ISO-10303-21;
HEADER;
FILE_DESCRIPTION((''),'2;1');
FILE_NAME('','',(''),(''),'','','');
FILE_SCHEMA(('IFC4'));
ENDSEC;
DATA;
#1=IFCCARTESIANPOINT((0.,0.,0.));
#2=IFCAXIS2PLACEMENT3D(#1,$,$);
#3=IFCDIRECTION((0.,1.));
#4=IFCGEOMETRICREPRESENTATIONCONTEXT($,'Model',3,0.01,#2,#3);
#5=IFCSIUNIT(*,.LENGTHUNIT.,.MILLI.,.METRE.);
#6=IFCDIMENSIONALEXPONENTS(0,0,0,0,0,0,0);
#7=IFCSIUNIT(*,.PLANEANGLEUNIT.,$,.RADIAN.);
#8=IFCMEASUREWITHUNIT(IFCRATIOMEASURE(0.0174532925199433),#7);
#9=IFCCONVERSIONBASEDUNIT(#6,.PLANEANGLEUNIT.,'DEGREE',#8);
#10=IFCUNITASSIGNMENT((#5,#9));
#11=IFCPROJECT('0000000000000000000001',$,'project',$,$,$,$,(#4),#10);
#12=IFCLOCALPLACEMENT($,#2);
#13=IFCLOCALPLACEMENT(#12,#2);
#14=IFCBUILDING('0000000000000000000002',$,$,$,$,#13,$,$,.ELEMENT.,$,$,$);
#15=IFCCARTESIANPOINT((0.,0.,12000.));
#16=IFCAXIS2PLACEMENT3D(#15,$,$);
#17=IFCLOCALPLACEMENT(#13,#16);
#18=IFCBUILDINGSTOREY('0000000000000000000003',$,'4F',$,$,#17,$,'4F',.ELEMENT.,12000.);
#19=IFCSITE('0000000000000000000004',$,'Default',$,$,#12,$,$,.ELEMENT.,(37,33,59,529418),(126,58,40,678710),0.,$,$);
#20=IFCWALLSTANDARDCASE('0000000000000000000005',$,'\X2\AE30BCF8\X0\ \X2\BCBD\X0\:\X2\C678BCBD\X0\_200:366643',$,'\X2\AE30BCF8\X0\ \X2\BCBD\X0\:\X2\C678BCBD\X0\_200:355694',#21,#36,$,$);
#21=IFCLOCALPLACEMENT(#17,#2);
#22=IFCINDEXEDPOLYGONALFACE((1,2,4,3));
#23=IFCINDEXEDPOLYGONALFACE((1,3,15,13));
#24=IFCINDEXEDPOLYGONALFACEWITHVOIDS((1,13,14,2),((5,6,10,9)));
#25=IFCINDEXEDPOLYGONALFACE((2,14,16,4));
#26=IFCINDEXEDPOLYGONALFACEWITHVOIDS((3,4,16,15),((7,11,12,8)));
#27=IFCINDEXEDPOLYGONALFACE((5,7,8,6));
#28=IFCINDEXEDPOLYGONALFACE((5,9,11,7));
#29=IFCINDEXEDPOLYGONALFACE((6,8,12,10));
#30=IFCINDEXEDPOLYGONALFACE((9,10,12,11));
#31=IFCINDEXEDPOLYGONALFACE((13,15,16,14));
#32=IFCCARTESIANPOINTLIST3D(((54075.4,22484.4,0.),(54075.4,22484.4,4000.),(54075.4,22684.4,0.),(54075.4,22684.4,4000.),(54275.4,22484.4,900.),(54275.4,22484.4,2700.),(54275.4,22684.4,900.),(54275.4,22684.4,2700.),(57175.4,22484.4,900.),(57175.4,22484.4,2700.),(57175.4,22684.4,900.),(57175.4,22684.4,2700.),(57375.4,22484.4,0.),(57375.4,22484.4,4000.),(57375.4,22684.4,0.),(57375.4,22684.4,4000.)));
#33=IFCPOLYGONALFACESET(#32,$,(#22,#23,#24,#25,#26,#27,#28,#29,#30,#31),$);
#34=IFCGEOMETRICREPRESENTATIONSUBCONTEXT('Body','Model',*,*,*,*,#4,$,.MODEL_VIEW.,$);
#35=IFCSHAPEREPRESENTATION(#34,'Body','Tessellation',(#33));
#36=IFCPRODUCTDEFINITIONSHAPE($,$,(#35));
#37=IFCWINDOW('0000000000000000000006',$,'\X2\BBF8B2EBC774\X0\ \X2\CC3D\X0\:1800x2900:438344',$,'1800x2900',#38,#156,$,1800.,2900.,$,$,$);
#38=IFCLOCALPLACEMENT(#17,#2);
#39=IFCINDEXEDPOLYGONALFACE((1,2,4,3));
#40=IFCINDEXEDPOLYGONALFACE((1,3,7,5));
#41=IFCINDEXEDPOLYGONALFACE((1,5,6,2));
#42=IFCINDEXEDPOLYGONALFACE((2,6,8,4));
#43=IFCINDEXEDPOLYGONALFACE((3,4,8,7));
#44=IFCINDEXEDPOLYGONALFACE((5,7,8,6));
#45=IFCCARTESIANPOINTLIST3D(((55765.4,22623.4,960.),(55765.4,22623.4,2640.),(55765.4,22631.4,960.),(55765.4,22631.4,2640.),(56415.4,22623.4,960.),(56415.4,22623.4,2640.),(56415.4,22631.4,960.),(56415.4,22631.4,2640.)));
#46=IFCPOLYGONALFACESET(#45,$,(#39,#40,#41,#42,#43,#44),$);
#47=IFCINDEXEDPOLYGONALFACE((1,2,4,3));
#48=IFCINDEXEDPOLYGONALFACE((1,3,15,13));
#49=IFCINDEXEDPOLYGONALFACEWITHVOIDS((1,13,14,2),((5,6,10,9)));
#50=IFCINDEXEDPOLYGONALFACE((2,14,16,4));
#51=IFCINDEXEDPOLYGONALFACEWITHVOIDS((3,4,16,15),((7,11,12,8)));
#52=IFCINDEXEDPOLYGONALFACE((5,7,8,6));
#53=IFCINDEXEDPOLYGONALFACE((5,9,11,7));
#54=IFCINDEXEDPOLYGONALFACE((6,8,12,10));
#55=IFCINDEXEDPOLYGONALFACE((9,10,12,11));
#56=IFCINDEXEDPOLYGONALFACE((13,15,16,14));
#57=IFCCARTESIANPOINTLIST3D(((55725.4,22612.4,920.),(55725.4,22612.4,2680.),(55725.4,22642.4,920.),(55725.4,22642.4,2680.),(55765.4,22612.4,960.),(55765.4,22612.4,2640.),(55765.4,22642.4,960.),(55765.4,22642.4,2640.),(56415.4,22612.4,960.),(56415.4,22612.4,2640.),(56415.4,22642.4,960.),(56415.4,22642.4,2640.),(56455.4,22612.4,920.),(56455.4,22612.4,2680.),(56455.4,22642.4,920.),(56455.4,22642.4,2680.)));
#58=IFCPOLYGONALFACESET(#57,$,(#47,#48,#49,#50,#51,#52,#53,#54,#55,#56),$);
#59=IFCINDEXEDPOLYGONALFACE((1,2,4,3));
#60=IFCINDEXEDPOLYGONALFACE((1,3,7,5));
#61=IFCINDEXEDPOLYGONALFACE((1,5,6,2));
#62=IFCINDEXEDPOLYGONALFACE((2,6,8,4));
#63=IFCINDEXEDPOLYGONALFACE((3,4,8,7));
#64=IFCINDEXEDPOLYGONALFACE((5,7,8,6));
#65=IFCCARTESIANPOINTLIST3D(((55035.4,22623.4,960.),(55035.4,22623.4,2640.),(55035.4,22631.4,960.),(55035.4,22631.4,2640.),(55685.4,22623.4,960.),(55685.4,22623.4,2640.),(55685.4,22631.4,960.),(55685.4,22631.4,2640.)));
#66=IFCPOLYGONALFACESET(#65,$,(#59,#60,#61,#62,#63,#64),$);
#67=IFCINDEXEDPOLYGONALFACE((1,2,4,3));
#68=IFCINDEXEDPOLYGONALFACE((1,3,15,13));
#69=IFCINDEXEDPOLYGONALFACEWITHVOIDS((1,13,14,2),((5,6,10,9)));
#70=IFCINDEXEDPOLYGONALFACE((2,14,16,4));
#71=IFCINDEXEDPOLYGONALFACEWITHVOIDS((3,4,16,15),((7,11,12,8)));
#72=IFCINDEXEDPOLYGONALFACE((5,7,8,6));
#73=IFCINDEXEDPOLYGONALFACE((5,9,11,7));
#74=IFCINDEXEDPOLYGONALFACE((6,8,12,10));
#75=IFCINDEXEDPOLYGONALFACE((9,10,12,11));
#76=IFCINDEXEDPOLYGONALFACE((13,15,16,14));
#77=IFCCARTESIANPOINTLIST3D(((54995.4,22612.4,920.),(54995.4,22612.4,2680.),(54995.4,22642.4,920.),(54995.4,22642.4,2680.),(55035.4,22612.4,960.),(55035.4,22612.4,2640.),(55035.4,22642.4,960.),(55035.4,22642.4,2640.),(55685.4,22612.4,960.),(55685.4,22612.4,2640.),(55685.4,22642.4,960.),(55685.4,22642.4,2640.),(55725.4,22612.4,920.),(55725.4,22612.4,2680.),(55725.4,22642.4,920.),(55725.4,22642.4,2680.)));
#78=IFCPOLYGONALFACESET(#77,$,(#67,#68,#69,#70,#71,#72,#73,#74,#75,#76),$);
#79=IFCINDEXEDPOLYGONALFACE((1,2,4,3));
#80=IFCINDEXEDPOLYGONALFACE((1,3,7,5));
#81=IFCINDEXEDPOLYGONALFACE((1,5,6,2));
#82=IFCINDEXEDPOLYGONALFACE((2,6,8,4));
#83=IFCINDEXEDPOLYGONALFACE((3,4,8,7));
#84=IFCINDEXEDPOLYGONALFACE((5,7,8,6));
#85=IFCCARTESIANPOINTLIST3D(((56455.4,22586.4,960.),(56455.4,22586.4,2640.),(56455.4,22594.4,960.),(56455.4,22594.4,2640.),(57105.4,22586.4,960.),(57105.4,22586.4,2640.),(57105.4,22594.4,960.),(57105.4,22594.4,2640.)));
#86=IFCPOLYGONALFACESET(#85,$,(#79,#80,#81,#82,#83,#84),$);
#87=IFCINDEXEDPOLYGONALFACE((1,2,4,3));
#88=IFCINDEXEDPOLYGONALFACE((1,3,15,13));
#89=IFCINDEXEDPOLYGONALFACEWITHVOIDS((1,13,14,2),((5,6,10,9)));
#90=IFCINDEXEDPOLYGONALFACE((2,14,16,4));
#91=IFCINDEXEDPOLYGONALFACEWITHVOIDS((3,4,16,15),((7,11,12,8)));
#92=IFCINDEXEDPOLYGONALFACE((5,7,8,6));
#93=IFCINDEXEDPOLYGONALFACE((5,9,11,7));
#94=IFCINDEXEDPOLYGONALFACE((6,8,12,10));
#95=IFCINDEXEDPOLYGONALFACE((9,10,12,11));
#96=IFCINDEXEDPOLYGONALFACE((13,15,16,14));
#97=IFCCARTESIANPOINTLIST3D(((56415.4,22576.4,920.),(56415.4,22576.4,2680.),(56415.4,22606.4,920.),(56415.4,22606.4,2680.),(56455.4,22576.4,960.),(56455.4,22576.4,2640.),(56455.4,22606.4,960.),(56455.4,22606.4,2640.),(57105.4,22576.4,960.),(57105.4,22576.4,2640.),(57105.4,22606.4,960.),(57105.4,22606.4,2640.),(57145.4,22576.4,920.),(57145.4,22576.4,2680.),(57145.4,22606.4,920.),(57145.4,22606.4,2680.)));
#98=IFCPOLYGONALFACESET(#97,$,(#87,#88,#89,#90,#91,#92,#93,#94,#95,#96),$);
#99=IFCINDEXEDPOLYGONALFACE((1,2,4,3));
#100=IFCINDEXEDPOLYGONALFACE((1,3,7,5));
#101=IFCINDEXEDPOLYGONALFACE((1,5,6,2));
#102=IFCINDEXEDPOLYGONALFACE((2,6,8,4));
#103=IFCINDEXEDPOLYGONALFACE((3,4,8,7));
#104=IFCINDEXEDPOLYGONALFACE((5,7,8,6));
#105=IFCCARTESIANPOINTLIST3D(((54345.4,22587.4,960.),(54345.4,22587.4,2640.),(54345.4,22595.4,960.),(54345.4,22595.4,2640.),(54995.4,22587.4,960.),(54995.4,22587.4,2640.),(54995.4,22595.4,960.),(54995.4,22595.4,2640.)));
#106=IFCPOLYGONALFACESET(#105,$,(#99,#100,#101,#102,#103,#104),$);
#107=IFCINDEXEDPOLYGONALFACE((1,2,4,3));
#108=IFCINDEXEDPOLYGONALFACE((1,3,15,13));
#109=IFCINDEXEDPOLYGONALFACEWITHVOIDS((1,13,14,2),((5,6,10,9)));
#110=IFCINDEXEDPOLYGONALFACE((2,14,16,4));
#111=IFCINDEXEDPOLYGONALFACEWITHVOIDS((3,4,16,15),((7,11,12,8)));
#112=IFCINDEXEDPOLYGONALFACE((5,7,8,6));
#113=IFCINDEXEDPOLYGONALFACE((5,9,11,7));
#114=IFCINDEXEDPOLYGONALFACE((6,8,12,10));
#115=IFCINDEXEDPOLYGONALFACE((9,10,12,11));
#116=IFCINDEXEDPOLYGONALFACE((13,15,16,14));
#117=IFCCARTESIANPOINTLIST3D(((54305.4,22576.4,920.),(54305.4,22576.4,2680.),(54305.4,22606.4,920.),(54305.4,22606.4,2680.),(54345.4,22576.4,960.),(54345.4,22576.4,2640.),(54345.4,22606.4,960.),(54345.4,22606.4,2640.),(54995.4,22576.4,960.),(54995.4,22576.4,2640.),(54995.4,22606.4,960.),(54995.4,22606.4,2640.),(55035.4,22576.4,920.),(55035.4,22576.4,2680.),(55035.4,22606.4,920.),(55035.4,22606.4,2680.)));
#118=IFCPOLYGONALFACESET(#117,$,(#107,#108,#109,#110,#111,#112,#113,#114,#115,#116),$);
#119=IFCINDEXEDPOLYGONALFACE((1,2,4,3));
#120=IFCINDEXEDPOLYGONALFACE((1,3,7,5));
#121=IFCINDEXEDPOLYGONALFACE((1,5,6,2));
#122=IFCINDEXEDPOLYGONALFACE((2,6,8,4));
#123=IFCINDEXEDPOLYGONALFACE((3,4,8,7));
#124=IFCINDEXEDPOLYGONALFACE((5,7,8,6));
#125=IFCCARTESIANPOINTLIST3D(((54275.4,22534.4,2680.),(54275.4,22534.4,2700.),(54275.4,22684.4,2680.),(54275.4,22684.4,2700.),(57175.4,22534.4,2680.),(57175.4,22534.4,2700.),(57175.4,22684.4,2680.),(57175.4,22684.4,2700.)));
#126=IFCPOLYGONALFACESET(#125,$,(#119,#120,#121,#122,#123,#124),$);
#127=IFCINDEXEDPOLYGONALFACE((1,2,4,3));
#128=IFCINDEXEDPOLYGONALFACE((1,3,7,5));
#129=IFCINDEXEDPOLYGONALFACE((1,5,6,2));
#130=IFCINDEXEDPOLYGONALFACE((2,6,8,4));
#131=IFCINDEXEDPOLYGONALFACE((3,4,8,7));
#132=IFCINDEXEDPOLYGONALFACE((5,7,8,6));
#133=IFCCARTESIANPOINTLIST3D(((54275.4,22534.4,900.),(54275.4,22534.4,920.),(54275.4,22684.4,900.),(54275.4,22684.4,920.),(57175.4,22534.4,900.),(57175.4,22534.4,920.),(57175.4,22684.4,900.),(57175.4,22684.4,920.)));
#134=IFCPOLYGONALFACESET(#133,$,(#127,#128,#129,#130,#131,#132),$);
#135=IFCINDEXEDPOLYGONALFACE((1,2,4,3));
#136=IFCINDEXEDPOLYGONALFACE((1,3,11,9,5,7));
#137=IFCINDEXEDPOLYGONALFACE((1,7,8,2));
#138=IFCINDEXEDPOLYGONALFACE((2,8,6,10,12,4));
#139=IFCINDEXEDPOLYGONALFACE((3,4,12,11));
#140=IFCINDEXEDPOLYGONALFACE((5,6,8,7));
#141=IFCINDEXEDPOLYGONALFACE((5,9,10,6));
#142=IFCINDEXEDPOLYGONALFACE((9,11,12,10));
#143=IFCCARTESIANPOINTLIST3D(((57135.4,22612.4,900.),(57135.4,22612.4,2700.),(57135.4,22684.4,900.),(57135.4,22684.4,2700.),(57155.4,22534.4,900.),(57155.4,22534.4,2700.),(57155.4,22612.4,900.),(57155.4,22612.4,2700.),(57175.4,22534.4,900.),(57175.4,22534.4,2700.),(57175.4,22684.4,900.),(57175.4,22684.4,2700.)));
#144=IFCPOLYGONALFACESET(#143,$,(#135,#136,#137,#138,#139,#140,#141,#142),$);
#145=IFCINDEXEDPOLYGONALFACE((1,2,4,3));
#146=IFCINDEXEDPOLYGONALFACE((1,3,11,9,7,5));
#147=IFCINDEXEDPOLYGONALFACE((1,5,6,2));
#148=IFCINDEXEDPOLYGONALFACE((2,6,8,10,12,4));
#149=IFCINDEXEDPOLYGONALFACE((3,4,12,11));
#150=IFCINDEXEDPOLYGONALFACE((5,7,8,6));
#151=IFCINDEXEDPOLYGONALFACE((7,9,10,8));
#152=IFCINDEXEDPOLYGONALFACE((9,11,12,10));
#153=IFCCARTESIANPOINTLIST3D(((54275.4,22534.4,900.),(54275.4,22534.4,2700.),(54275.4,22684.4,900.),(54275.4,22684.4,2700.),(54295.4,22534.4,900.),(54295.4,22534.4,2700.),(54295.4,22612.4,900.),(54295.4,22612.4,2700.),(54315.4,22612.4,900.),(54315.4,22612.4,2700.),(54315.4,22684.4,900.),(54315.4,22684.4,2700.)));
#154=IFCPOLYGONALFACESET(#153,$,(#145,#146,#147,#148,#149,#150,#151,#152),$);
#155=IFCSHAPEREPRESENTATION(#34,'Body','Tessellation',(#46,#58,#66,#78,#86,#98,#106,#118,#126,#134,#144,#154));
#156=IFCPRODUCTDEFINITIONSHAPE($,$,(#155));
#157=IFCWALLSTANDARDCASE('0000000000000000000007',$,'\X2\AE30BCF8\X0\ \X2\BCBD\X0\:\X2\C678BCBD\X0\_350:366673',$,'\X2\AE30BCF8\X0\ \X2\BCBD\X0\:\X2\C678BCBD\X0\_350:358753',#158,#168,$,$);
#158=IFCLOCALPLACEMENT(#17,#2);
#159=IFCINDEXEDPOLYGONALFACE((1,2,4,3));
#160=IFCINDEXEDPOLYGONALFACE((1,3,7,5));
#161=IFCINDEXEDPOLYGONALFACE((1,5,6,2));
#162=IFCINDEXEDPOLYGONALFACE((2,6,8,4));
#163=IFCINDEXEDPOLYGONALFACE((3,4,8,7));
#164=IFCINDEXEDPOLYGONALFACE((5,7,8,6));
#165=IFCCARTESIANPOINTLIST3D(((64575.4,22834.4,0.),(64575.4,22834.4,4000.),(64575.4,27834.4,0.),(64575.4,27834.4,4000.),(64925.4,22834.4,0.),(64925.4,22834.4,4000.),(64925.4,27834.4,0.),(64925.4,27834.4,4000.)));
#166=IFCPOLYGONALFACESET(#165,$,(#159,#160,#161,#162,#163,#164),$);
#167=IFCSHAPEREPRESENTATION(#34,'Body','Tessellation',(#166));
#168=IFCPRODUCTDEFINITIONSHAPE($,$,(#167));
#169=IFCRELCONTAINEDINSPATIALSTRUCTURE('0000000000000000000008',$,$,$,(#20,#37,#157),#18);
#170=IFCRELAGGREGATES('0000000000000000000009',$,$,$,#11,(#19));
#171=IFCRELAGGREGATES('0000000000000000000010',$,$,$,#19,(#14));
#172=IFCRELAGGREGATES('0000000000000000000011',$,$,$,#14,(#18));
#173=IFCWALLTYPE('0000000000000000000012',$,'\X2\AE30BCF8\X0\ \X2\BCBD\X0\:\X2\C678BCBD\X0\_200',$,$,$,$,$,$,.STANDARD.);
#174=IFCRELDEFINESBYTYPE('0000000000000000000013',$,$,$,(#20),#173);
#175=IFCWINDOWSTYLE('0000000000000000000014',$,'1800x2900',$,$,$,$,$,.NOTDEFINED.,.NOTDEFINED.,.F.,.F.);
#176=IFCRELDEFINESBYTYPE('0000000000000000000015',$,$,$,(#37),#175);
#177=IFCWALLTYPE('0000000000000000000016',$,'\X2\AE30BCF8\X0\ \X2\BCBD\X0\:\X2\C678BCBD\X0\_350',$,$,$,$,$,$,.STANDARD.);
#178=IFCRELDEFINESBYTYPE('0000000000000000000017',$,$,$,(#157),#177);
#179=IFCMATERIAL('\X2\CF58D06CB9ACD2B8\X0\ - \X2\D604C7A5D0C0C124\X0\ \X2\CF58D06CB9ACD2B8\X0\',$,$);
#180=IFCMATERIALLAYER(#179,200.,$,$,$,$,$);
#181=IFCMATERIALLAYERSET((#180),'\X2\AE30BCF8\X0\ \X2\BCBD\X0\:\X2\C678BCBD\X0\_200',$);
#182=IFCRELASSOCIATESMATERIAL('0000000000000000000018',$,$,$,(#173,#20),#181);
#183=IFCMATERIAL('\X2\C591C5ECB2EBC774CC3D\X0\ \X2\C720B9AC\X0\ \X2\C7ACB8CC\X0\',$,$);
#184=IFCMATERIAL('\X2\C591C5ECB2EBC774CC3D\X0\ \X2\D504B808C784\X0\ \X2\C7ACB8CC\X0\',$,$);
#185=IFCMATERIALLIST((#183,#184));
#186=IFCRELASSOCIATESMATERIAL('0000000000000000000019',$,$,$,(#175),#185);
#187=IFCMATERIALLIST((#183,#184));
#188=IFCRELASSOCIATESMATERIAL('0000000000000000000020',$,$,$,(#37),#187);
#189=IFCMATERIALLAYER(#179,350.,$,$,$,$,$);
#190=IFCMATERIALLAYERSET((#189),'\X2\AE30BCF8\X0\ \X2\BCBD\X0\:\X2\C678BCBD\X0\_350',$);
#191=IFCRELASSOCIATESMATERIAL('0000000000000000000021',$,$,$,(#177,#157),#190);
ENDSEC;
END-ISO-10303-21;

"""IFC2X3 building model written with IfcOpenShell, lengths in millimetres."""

from ifc_helpers import new_model, entity, si_unit, converted_unit, direction, frame, frame_2d, origin, origin_2d_with_axis, place, context, subcontext, project, spatial, polyline, rectangle, outline, extrude, source, transform, mapped, material, material_list, layer, layer_set, layer_usage, type_object, type_shapes, element, fill, save


model = new_model("IFC2X3")

# Units and contexts
model_context = context("Model", 3, precision=0.01, world=origin(), true_north=direction((0.0, 1.0)))
body_context = subcontext(model_context, "Body", "Model", "MODEL_VIEW")
ifc_project = project(units=[si_unit("LENGTHUNIT", "METRE", prefix="MILLI"), converted_unit("PLANEANGLEUNIT", "DEGREE", entity("IfcRatioMeasure", 0.0174532925199433), si_unit("PLANEANGLEUNIT", "RADIAN"), dimensions=[0, 0, 0, 0, 0, 0, 0])], contexts=[model_context])

# Site, building, storey
site_placement = place(None, origin())
site = spatial("IfcSite", under=ifc_project, at=site_placement, Name="Default", CompositionType="ELEMENT", RefLatitude=(37, 33, 59, 529418), RefLongitude=(126, 58, 40, 678710), RefElevation=0.0)
building_placement = place(site_placement, origin())
building = spatial("IfcBuilding", under=site, at=building_placement, CompositionType="ELEMENT")
storey_placement = place(building_placement, frame((0.0, 0.0, 12000.0)))
storey = spatial("IfcBuildingStorey", under=building, at=storey_placement, Name="4F", LongName="4F", CompositionType="ELEMENT", Elevation=12000.0)

# Wall, opening, window
ifc_material_1 = material(Name="콘크리트 - 현장타설 콘크리트")
ifc_layer_1 = layer(ifc_material_1, 200.0)
ifc_layer_set_1 = layer_set([ifc_layer_1], Name="기본 벽:외벽_200")
wall_type_1 = type_object("IfcWallType", Name="기본 벽:외벽_200", PredefinedType="STANDARD", material=ifc_layer_set_1)
ifc_material_2 = material(Name="양여닫이창 유리 재료")
ifc_material_3 = material(Name="양여닫이창 프레임 재료")
ifc_material_list_1 = material_list([ifc_material_2, ifc_material_3])
window_style = type_object("IfcWindowStyle", Name="1800x2900", ConstructionType="NOTDEFINED", OperationType="NOTDEFINED", ParameterTakesPrecedence=False, Sizeable=False, material=ifc_material_list_1)
shared_shape_1 = source(origin(), body_context, "Body", "SweptSolid", [
    extrude(rectangle(XDim=8.0, YDim=650.0, at=frame_2d((0.0, 0.0), x_axis=(1.0, 0.0))), frame((1815.0, 143.0, 60.0), z_axis=(0.0, 0.0, 1.0), x_axis=(0.0, 1.0, 0.0)), (0.0, 0.0, 1.0), 1680.0),
    extrude(outline(polyline([(-880.0, -365.0), (880.0, -365.0), (880.0, 365.0), (-880.0, 365.0), (-880.0, -365.0)]), holes=[polyline([(840.0, -325.0), (-840.0, -325.0), (-840.0, 325.0), (840.0, 325.0), (840.0, -325.0)])]), frame((1815.0, 128.0, 900.0), z_axis=(0.0, 1.0, 0.0), x_axis=(0.0, 0.0, -1.0)), (0.0, 0.0, 1.0), 30.0),
    extrude(rectangle(XDim=8.0, YDim=650.0, at=frame_2d((0.0, 0.0), x_axis=(1.0, 0.0))), frame((1085.0, 143.0, 60.0), z_axis=(0.0, 0.0, 1.0), x_axis=(0.0, 1.0, 0.0)), (0.0, 0.0, 1.0), 1680.0),
    extrude(outline(polyline([(-880.0, -365.0), (880.0, -365.0), (880.0, 365.0), (-880.0, 365.0), (-880.0, -365.0)]), holes=[polyline([(840.0, -325.0), (-840.0, -325.0), (-840.0, 325.0), (840.0, 325.0), (840.0, -325.0)])]), frame((1085.0, 128.0, 900.0), z_axis=(0.0, 1.0, 0.0), x_axis=(0.0, 0.0, -1.0)), (0.0, 0.0, 1.0), 30.0),
    extrude(rectangle(XDim=8.0, YDim=650.0, at=frame_2d((0.0, 0.0), x_axis=(1.0, 0.0))), frame((2505.0, 106.0, 60.0), z_axis=(0.0, 0.0, 1.0), x_axis=(0.0, 1.0, 0.0)), (0.0, 0.0, 1.0), 1680.0),
    extrude(outline(polyline([(-880.0, -365.0), (880.0, -365.0), (880.0, 365.0), (-880.0, 365.0), (-880.0, -365.0)]), holes=[polyline([(840.0, -325.0), (-840.0, -325.0), (-840.0, 325.0), (840.0, 325.0), (840.0, -325.0)])]), frame((2505.0, 92.0, 900.0), z_axis=(0.0, 1.0, 0.0), x_axis=(0.0, 0.0, -1.0)), (0.0, 0.0, 1.0), 30.0),
    extrude(rectangle(XDim=8.0, YDim=650.0, at=origin_2d_with_axis()), frame((395.0, 107.0, 60.0), z_axis=(0.0, 0.0, 1.0), x_axis=(0.0, 1.0, 0.0)), (0.0, 0.0, 1.0), 1680.0),
    extrude(outline(polyline([(-880.0, -365.0), (880.0, -365.0), (880.0, 365.0), (-880.0, 365.0), (-880.0, -365.0)]), holes=[polyline([(840.0, -325.0), (-840.0, -325.0), (-840.0, 325.0), (840.0, 325.0), (840.0, -325.0)])]), frame((395.0, 92.0, 900.0), z_axis=(0.0, 1.0, 0.0), x_axis=(0.0, 0.0, -1.0)), (0.0, 0.0, 1.0), 30.0),
    extrude(rectangle(XDim=2900.0, YDim=150.0, at=origin_2d_with_axis()), frame((1450.0, 125.0, 1780.0), z_axis=(0.0, 0.0, 1.0), x_axis=(-1.0, 0.0, 0.0)), (0.0, 0.0, 1.0), 20.0),
    extrude(rectangle(XDim=2900.0, YDim=150.0, at=origin_2d_with_axis()), frame((1450.0, 125.0, 0.0), z_axis=(0.0, 0.0, 1.0), x_axis=(-1.0, 0.0, 0.0)), (0.0, 0.0, 1.0), 20.0),
    extrude(outline(polyline([(-74.0, -20.0), (-2.0, -20.0), (-2.0, 0.0), (76.0, 0.0), (76.0, 20.0), (-74.0, 20.0), (-74.0, -20.0)])), frame((2880.0, 126.0, 0.0), z_axis=(0.0, 0.0, 1.0), x_axis=(0.0, -1.0, 0.0)), (0.0, 0.0, 1.0), 1800.0),
    extrude(outline(polyline([(-20.0, -74.0), (20.0, -74.0), (20.0, 76.0), (0.0, 76.0), (0.0, -2.0), (-20.0, -2.0), (-20.0, -74.0)])), frame((20.0, 126.0, 0.0), z_axis=(0.0, 0.0, 1.0), x_axis=(-1.0, 0.0, 0.0)), (0.0, 0.0, 1.0), 1800.0),
])
type_shapes(window_style, [shared_shape_1])
ifc_layer_usage_1 = layer_usage(ifc_layer_set_1, "AXIS2", "NEGATIVE", 100.0)
wall_1_placement = place(storey_placement, frame((57375.4, 22584.4, 0.0), z_axis=(0.0, 0.0, 1.0), x_axis=(-1.0, 0.0, 0.0)))
wall_1 = element("IfcWallStandardCase", 1, at=wall_1_placement, inside=storey, type_object=wall_type_1, material=ifc_layer_usage_1, Name="기본 벽:외벽_200:366643", ObjectType="기본 벽:외벽_200:355694", context=body_context, shape_type="SweptSolid", body=[
    extrude(rectangle(XDim=3300.0, YDim=200.0, at=frame_2d((1650.0, 0.0), x_axis=(-1.0, 0.0))), origin(), (0.0, 0.0, 1.0), 4000.0),
])
opening_1_placement = place(wall_1_placement, frame((3100.0, 100.0, 900.0)))
opening_1 = element("IfcOpeningElement", 2, at=opening_1_placement, cuts=wall_1, ObjectType="Opening", context=body_context, shape_type="SweptSolid", body=[
    extrude(rectangle(XDim=1800.0, YDim=2900.0, at=frame_2d((900.0, 1450.0), x_axis=(1.0, 0.0))), frame((0.0, 0.0, 0.0), z_axis=(0.0, -1.0, 0.0), x_axis=(0.0, 0.0, 1.0)), (0.0, 0.0, 1.0), 200.0),
])
ifc_material_list_2 = material_list([ifc_material_2, ifc_material_3])
window_1_placement = place(opening_1_placement, frame((0.0, 0.0, 0.0), z_axis=(0.0, 0.0, 1.0), x_axis=(-1.0, 0.0, 0.0)))
window_1 = element("IfcWindow", 3, at=window_1_placement, inside=storey, type_object=window_style, material=ifc_material_list_2, Name="미닫이 창:1800x2900:438344", ObjectType="1800x2900", OverallHeight=1800.0, OverallWidth=2900.0, context=body_context, shape_type="MappedRepresentation", body=[
    mapped(shared_shape_1, transform((0.0, 0.0, 0.0), scale=1.0)),
])
fill(opening_1, window_1)

# Wall
ifc_layer_2 = layer(ifc_material_1, 350.0)
ifc_layer_set_2 = layer_set([ifc_layer_2], Name="기본 벽:외벽_350")
ifc_layer_usage_2 = layer_usage(ifc_layer_set_2, "AXIS2", "NEGATIVE", 175.0)
wall_type_2 = type_object("IfcWallType", Name="기본 벽:외벽_350", PredefinedType="STANDARD", material=ifc_layer_set_2)
wall_2_placement = place(storey_placement, frame((64750.4, 27834.4, 0.0), z_axis=(0.0, 0.0, 1.0), x_axis=(0.0, -1.0, 0.0)))
element("IfcWallStandardCase", 4, at=wall_2_placement, inside=storey, type_object=wall_type_2, material=ifc_layer_usage_2, Name="기본 벽:외벽_350:366673", ObjectType="기본 벽:외벽_350:358753", context=body_context, shape_type="SweptSolid", body=[
    extrude(rectangle(XDim=5000.0, YDim=350.0, at=frame_2d((2500.0, 0.0), x_axis=(-1.0, 0.0))), origin(), (0.0, 0.0, 1.0), 4000.0),
])

save(model, "model.ifc")
